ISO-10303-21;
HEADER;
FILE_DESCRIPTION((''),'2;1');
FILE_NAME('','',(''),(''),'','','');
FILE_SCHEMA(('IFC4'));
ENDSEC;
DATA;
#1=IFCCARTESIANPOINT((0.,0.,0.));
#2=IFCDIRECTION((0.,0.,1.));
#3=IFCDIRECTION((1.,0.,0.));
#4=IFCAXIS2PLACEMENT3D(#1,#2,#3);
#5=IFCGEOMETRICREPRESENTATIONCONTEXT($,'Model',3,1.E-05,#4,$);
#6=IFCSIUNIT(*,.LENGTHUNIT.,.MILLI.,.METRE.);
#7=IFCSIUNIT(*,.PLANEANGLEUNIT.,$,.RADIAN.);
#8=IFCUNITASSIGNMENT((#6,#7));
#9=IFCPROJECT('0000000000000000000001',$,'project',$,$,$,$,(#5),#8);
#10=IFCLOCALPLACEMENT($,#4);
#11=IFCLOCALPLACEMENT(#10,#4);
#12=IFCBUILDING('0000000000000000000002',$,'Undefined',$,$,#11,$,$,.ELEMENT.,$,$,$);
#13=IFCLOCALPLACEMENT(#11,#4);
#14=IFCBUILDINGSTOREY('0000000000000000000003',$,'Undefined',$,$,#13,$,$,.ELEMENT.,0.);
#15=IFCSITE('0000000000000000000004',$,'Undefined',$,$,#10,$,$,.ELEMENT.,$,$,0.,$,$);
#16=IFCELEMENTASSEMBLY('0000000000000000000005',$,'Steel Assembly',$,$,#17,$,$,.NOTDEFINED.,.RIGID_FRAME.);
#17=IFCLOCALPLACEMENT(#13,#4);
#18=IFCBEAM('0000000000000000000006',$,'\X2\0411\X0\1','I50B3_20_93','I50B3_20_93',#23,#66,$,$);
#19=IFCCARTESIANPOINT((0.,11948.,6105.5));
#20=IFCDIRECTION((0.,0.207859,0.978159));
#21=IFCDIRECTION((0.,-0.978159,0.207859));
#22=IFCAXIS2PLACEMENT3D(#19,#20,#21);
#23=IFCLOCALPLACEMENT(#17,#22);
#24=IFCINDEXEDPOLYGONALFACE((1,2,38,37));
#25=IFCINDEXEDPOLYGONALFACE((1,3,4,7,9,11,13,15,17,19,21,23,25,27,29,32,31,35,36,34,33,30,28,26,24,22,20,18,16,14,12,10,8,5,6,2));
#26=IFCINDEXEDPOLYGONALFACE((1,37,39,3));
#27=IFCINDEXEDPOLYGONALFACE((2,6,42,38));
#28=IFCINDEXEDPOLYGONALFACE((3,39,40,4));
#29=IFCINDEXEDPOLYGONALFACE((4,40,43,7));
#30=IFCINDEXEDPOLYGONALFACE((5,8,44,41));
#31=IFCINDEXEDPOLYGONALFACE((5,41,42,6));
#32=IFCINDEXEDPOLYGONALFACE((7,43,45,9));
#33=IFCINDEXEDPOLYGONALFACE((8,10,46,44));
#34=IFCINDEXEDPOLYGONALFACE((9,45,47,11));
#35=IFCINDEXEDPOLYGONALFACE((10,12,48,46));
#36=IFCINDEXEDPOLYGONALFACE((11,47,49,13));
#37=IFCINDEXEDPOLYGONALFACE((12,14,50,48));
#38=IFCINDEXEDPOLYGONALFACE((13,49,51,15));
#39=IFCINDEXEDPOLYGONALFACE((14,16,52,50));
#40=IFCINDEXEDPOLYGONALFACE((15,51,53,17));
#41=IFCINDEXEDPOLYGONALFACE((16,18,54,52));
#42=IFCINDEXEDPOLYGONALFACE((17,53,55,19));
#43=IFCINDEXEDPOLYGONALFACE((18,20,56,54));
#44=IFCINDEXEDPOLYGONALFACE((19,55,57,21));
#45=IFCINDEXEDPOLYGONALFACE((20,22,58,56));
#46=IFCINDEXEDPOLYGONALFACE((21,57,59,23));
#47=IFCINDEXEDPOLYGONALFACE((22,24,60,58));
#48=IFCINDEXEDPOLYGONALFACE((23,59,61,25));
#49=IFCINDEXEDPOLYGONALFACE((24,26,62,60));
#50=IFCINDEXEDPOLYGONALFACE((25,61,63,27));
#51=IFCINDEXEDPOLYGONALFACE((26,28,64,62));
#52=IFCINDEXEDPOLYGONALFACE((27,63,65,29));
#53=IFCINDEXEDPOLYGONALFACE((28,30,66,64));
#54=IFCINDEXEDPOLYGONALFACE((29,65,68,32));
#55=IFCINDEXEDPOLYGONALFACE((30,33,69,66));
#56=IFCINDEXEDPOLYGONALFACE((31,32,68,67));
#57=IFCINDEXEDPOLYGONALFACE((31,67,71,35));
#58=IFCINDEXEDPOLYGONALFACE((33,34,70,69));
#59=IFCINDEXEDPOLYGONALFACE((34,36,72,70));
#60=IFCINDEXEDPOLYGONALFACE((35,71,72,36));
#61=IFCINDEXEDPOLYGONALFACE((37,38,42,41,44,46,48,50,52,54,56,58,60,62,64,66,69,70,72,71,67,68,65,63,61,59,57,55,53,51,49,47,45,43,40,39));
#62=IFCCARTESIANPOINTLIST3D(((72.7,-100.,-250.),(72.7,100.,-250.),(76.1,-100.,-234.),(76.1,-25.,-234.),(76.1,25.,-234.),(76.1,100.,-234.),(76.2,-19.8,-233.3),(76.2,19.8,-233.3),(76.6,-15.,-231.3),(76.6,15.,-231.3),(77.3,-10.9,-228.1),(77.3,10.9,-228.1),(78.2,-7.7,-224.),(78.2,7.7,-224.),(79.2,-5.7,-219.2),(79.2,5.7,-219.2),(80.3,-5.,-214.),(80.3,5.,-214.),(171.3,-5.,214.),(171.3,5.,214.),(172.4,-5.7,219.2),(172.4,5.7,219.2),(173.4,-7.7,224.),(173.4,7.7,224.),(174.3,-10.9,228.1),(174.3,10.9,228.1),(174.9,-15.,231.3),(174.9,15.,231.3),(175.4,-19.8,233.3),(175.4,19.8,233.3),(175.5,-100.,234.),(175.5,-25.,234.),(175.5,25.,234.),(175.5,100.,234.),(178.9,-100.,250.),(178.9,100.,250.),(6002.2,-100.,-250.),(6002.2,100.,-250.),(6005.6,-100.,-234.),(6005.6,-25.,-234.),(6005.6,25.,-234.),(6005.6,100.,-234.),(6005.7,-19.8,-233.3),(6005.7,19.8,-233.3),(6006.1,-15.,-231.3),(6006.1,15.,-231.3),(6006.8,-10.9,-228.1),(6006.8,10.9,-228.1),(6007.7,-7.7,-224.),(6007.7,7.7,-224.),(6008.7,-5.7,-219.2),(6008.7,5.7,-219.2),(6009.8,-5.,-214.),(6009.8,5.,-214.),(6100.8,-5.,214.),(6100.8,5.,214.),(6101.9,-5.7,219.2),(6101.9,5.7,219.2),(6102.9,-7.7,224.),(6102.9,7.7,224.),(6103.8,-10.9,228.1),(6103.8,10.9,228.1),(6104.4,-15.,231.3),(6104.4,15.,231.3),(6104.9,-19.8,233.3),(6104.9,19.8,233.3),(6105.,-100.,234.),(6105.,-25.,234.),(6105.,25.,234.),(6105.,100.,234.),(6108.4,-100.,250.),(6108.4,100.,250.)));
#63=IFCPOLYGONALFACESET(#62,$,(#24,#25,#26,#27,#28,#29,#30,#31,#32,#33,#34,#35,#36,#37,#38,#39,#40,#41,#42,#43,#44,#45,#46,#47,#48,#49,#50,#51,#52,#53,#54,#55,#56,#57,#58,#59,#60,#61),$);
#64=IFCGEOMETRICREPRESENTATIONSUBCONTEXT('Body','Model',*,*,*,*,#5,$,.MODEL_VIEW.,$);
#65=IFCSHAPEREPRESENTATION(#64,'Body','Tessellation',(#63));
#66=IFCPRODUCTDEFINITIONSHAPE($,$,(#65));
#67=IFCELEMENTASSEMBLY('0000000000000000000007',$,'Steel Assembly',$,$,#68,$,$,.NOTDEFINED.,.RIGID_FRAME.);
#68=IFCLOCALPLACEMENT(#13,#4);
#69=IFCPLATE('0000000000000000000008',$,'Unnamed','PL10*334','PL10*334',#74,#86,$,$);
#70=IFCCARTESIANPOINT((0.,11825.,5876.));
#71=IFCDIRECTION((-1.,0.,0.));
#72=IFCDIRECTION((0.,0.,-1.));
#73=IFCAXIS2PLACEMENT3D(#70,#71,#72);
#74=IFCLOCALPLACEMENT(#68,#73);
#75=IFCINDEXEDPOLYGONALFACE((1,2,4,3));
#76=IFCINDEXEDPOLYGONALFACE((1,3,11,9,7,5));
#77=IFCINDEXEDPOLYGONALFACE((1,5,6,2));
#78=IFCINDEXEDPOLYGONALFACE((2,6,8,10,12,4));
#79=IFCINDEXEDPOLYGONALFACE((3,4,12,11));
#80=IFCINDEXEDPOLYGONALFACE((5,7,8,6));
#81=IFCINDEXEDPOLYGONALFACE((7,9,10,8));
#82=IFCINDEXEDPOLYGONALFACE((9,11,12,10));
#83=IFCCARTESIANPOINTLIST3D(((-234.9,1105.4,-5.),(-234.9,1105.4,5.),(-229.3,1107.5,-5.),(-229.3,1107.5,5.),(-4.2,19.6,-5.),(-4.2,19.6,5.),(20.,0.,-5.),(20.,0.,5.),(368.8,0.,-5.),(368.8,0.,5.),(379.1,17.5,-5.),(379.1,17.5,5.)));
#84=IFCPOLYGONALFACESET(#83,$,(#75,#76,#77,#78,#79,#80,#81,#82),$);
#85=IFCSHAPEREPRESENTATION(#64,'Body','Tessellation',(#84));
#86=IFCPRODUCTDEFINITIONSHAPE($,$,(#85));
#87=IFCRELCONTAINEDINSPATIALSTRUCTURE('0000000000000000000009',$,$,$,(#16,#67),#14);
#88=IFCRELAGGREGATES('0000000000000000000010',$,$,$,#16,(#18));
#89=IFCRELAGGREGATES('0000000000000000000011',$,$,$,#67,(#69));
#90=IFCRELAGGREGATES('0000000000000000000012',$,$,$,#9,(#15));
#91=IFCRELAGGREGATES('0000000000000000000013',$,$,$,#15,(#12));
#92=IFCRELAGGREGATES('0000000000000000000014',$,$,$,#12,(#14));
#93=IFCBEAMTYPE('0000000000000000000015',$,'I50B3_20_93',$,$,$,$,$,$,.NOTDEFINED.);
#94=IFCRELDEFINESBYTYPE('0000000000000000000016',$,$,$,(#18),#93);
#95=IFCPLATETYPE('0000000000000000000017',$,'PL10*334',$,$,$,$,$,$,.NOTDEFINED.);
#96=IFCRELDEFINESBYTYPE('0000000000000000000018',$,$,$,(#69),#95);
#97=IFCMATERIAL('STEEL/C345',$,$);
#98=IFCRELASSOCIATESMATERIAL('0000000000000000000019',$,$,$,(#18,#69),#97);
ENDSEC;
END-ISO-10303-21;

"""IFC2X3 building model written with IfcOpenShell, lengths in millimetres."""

from ifc_helpers import new_model, si_unit, frame, origin_with_axes, origin_2d_with_axis, place, context, subcontext, project, spatial, polyline, i_section, outline, extrude, clip, halfspace, material, type_object, element, aggregate, save


model = new_model("IFC2X3")

# Units and contexts
model_context = context("Model", 3, precision=1e-05, world=origin_with_axes())
body_context = subcontext(model_context, "Body", "Model", "MODEL_VIEW")
ifc_project = project(units=[si_unit("LENGTHUNIT", "METRE", prefix="MILLI"), si_unit("PLANEANGLEUNIT", "RADIAN")], contexts=[model_context])

# Site, building, storey
site_placement = place(None, origin_with_axes())
site = spatial("IfcSite", under=ifc_project, at=site_placement, Name="Undefined", CompositionType="ELEMENT", RefElevation=0.0)
building_placement = place(site_placement, origin_with_axes())
building = spatial("IfcBuilding", under=site, at=building_placement, Name="Undefined", CompositionType="ELEMENT")
storey_placement = place(building_placement, origin_with_axes())
storey = spatial("IfcBuildingStorey", under=building, at=storey_placement, Name="Undefined", CompositionType="ELEMENT", Elevation=0.0)

# Element assembly, beam
assembly_1_placement = place(storey_placement, origin_with_axes())
assembly_1 = element("IfcElementAssembly", 1, at=assembly_1_placement, inside=storey, Name="Steel Assembly", AssemblyPlace="NOTDEFINED", PredefinedType="RIGID_FRAME")
ifc_material = material(Name="STEEL/C345")
beam_type_1 = type_object("IfcBeamType", Name="I50B3_20_93", PredefinedType="NOTDEFINED")
beam_1_placement = place(assembly_1_placement, frame((0.0, 11948.0, 6105.5), z_axis=(0.0, 0.207859, 0.978159), x_axis=(0.0, -0.978159, 0.207859)))
beam_1 = element("IfcBeam", 2, at=beam_1_placement, type_object=beam_type_1, material=ifc_material, Name="Б1", Description="I50B3_20_93", ObjectType="I50B3_20_93", context=body_context, shape_type="Clipping", body=[
    clip(clip(extrude(i_section(OverallWidth=200.0, OverallDepth=500.0, WebThickness=10.0, FlangeThickness=16.0, FilletRadius=20.0, at=origin_2d_with_axis()), frame((6134.0, 0.0, 0.0), z_axis=(-1.0, 0.0, 0.0), x_axis=(0.0, -1.0, 0.0)), (0.0, 0.0, 1.0), 6134.0), halfspace(frame((-125.5, -110.0, -1182.5), z_axis=(-0.978159, 0.0, 0.207859), x_axis=(0.0, 1.0, 0.0)), False)), halfspace(frame((6109.5, -110.0, 255.2), z_axis=(0.978159, 0.0, -0.207859), x_axis=(0.0, 1.0, 0.0)), False)),
])
aggregate(assembly_1, [beam_1])

# Element assembly, plate
assembly_2_placement = place(storey_placement, origin_with_axes())
assembly_2 = element("IfcElementAssembly", 3, at=assembly_2_placement, inside=storey, Name="Steel Assembly", AssemblyPlace="NOTDEFINED", PredefinedType="RIGID_FRAME")
plate_type_1 = type_object("IfcPlateType", Name="PL10*334", PredefinedType="NOTDEFINED")
plate_1_placement = place(assembly_2_placement, frame((0.0, 11825.0, 5876.0), z_axis=(-1.0, 0.0, 0.0), x_axis=(0.0, 0.0, -1.0)))
plate_1 = element("IfcPlate", 4, at=plate_1_placement, type_object=plate_type_1, material=ifc_material, Name="Unnamed", Description="PL10*334", ObjectType="PL10*334", context=body_context, shape_type="SweptSolid", body=[
    extrude(outline(polyline([(-4.2, 19.6), (20.0, 0.0), (368.8, 0.0), (379.1, 17.5), (-229.3, 1107.5), (-234.9, 1105.4), (-4.2, 19.6)])), frame((0.0, 0.0, -5.0), z_axis=(0.0, 0.0, 1.0), x_axis=(1.0, 0.0, 0.0)), (0.0, 0.0, 1.0), 10.0),
])
aggregate(assembly_2, [plate_1])

save(model, "model.ifc")
